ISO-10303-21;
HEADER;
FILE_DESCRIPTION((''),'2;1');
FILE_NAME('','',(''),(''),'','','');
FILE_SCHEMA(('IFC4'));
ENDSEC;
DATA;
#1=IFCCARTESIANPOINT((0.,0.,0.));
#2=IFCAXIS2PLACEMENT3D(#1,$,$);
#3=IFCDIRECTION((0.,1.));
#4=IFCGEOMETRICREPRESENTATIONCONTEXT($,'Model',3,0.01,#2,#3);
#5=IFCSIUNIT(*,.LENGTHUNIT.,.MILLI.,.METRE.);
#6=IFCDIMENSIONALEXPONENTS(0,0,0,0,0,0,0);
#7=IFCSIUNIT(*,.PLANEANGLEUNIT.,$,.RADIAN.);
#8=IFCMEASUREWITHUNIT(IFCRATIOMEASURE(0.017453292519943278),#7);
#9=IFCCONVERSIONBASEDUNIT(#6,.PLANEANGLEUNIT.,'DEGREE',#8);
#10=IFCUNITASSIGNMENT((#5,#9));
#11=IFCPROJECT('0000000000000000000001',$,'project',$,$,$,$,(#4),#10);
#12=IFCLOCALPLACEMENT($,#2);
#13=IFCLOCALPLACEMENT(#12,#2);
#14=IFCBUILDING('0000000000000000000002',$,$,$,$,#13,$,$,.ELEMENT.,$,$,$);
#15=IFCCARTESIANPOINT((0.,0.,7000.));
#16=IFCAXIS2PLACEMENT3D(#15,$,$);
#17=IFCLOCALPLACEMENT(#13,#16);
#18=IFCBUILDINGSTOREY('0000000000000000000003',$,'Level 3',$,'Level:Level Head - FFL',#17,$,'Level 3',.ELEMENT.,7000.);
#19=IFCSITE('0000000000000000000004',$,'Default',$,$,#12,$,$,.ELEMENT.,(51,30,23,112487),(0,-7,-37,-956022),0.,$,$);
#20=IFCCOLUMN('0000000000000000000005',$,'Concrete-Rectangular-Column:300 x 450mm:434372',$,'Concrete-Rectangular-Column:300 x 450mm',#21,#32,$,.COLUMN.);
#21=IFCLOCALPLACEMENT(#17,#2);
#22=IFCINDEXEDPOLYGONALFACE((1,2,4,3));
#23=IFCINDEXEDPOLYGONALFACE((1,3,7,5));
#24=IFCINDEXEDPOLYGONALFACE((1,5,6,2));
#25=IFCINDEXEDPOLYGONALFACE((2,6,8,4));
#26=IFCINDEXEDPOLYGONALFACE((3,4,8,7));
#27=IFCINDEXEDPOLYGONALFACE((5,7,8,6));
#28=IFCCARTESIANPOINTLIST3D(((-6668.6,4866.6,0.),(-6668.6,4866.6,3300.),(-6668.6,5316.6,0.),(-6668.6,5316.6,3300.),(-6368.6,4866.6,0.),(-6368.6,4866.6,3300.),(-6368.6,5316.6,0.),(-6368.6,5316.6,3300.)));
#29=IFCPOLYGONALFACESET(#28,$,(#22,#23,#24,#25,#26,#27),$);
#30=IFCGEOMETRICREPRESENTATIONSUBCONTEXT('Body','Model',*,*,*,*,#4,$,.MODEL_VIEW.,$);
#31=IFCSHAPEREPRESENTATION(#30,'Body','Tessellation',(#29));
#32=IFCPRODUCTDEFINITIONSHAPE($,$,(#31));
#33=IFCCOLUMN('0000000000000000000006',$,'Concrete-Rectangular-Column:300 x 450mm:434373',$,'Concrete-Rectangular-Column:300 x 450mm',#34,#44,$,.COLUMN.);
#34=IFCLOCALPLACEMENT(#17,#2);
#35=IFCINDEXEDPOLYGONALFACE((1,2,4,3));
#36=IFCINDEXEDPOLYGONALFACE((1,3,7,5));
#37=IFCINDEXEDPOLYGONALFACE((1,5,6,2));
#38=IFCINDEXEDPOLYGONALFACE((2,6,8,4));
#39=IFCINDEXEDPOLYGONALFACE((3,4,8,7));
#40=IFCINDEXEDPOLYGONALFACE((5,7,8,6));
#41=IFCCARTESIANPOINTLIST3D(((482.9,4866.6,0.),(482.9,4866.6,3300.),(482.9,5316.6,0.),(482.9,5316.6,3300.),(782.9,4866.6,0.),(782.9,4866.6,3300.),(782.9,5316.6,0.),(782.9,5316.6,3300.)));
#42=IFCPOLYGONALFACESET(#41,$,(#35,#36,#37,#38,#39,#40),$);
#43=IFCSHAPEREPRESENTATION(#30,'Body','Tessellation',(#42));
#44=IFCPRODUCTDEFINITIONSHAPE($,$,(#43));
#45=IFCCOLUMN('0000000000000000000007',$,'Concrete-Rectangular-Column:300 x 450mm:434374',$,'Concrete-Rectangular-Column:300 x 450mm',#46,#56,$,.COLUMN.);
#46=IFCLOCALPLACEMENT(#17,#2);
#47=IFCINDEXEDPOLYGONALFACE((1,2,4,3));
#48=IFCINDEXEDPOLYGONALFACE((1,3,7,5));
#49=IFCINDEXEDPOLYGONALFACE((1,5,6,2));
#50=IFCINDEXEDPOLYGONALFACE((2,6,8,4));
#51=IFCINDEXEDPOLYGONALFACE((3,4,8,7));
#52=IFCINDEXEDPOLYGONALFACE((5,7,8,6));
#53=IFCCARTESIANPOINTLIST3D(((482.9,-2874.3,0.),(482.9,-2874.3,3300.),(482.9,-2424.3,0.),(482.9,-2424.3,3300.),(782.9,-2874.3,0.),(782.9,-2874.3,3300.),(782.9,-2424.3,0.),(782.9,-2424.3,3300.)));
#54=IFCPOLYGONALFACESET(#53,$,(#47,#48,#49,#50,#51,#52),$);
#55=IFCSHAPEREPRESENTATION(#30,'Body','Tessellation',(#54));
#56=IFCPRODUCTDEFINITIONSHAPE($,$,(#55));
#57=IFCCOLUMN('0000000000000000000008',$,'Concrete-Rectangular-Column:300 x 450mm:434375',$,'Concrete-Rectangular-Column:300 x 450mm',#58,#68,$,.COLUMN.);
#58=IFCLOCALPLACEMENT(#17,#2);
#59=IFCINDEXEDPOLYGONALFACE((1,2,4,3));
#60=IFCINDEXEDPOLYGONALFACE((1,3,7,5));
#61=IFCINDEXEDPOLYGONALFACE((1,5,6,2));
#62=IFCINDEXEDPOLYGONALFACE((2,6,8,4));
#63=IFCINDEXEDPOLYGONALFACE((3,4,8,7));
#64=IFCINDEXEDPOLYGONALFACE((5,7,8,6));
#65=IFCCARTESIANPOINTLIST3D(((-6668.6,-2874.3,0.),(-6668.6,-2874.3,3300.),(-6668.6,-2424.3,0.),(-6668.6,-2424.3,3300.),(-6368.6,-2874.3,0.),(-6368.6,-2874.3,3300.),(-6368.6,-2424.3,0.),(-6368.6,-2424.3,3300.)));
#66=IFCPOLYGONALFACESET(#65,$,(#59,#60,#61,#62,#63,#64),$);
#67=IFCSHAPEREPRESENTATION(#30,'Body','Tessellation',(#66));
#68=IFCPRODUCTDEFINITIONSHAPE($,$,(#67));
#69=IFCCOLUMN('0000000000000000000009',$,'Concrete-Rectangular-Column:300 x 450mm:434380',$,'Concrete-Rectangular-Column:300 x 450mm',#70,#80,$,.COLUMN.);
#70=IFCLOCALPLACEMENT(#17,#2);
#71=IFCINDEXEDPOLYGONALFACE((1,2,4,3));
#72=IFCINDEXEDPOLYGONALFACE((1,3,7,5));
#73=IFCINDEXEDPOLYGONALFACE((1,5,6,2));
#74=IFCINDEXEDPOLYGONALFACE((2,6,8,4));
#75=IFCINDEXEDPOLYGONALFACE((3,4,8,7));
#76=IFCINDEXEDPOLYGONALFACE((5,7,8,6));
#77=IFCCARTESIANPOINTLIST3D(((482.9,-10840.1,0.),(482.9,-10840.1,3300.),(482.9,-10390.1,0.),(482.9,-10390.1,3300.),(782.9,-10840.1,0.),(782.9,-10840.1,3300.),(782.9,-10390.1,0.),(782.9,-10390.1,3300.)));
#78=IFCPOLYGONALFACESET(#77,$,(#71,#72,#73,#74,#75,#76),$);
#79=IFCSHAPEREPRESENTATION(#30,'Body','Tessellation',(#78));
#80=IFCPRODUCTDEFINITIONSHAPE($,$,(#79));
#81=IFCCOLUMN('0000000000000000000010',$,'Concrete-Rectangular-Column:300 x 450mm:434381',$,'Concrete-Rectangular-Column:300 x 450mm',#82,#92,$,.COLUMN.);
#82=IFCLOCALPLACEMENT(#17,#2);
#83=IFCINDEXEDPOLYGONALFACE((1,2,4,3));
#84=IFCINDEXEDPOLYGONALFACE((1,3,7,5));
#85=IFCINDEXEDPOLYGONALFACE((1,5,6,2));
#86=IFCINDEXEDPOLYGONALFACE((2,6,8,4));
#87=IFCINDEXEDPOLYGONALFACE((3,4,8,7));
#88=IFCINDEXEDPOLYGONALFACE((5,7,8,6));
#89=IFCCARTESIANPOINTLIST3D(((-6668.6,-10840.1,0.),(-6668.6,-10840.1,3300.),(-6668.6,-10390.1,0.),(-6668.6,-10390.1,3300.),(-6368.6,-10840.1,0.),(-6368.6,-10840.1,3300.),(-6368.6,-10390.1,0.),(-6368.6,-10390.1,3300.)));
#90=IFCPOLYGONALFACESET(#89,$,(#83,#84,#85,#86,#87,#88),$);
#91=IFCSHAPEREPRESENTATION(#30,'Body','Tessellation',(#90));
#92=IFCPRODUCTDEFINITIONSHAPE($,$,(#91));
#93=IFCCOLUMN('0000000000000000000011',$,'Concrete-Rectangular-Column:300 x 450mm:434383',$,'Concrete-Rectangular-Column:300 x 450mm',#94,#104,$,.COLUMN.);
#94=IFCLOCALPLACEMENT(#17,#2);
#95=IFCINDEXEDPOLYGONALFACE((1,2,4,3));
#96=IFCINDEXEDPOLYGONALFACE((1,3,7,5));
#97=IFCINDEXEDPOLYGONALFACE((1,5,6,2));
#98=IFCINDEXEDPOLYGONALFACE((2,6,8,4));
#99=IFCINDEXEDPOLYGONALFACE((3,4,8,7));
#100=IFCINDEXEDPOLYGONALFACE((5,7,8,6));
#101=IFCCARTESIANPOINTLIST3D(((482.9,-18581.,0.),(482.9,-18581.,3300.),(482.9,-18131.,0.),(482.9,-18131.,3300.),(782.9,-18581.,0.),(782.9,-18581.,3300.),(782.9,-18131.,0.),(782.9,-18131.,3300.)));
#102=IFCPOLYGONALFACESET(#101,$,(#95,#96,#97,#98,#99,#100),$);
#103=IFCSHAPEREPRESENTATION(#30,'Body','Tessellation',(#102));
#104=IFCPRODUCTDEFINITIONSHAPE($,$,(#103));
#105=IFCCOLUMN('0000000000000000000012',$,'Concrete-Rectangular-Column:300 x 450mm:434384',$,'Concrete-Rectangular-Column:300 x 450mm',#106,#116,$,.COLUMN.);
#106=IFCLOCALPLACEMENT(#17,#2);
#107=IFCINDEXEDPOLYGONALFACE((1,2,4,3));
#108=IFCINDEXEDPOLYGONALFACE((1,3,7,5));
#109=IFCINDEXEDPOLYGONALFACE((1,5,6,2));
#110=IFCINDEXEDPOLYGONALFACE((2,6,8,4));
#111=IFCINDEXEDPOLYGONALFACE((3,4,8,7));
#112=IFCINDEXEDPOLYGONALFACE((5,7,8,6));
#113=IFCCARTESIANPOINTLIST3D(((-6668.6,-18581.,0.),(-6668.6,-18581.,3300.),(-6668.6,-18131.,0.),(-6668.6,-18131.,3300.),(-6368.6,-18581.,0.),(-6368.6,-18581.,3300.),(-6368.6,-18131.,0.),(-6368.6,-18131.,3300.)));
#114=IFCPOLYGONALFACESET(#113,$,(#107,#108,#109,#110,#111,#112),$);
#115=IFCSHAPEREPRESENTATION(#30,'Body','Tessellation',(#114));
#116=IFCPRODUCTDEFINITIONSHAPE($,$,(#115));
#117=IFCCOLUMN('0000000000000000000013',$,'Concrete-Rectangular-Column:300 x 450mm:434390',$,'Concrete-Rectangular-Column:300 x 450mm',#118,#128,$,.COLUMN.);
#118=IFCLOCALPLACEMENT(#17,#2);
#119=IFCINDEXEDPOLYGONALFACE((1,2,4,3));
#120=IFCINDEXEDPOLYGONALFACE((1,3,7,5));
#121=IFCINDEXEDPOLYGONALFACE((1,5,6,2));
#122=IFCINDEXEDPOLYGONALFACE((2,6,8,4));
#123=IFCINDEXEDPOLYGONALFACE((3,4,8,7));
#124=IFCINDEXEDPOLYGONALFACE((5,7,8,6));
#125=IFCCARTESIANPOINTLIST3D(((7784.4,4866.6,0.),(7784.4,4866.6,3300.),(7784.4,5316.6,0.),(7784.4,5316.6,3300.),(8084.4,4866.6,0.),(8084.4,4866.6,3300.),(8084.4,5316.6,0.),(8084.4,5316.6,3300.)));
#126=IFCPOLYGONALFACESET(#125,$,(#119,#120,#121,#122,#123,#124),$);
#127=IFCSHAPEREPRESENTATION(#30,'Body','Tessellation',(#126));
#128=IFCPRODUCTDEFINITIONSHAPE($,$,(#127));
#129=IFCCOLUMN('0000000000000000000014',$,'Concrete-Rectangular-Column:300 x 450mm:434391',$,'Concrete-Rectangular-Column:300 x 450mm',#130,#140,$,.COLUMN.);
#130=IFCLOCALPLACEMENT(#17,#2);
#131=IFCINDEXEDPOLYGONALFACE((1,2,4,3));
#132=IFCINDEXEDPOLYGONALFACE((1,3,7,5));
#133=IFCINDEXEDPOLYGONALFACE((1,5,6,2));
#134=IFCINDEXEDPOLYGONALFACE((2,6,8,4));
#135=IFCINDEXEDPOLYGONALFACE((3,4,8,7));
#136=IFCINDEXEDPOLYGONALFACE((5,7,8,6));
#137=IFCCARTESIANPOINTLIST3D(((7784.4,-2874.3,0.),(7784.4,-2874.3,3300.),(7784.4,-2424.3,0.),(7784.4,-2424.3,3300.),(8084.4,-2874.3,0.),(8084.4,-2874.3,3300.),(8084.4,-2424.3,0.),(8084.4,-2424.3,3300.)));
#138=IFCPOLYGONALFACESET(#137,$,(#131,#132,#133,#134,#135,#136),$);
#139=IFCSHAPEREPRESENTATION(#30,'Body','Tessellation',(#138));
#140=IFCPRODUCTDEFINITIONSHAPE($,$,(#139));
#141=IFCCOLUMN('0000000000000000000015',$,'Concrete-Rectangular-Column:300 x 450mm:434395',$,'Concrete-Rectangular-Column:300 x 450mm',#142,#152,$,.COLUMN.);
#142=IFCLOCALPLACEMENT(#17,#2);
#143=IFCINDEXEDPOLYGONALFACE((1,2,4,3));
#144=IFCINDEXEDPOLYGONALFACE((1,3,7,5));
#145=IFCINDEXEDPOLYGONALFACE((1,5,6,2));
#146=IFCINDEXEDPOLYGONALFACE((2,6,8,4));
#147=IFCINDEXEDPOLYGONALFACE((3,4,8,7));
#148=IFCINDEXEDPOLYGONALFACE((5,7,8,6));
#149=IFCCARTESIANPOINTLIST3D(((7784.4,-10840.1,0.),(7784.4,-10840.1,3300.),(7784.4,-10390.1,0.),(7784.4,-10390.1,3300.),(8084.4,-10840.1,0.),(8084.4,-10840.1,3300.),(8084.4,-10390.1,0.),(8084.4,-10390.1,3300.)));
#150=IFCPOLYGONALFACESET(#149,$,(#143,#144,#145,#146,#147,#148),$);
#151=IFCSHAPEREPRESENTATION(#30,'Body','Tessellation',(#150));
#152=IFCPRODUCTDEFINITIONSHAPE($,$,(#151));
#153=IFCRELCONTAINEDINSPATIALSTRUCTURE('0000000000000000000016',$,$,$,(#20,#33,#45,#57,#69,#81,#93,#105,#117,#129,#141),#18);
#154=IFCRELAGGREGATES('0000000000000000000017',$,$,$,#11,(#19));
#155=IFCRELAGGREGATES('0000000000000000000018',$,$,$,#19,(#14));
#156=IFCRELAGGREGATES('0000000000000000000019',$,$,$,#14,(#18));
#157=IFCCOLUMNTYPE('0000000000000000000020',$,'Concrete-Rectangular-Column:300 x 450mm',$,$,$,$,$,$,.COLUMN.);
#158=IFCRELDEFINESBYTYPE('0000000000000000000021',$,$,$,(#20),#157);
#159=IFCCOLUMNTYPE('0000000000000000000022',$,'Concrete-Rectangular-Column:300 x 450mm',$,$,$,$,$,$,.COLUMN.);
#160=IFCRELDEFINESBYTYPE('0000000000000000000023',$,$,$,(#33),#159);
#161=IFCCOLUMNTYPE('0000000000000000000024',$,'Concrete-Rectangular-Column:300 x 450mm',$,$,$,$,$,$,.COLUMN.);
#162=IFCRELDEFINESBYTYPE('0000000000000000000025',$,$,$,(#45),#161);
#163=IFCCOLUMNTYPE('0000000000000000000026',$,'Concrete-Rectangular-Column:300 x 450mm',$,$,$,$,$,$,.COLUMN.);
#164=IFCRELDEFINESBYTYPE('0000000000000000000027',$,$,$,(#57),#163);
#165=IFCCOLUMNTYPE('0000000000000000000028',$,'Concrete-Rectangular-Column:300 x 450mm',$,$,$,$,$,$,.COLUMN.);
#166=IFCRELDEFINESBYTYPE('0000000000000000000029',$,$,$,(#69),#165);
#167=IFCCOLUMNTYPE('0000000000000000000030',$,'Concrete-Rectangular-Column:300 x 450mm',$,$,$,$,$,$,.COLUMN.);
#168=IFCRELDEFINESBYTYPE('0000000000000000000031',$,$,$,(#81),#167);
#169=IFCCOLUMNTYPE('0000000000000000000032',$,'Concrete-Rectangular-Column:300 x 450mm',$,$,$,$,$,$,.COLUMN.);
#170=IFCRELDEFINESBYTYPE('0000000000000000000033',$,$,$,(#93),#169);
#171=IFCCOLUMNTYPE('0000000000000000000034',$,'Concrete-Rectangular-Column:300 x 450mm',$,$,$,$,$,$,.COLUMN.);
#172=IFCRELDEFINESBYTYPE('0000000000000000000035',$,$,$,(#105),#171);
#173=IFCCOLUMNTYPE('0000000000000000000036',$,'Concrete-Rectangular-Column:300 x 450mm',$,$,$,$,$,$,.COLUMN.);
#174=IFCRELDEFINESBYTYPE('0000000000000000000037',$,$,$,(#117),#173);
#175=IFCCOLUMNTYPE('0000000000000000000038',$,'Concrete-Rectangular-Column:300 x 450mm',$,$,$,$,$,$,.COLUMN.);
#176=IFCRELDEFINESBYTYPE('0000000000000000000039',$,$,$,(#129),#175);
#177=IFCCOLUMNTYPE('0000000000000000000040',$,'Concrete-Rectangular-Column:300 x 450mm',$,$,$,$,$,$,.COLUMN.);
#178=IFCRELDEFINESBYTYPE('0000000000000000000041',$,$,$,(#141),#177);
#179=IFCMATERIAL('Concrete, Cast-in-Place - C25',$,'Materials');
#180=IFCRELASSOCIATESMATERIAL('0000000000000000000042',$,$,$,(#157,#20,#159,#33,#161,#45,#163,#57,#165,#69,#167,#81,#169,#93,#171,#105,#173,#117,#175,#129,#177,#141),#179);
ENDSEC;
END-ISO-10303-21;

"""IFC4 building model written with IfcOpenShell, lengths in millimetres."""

from ifc_helpers import new_model, entity, si_unit, converted_unit, direction, frame, origin, place, context, subcontext, project, spatial, indexed_curve, outline, extrude, source, transform, mapped, material, type_object, type_shapes, element, save


model = new_model("IFC4")

# Units and contexts
model_context = context("Model", 3, precision=0.01, world=origin(), true_north=direction((0.0, 1.0)))
body_context = subcontext(model_context, "Body", "Model", "MODEL_VIEW")
ifc_project = project(units=[si_unit("LENGTHUNIT", "METRE", prefix="MILLI"), converted_unit("PLANEANGLEUNIT", "DEGREE", entity("IfcRatioMeasure", 0.017453292519943278), si_unit("PLANEANGLEUNIT", "RADIAN"), dimensions=[0, 0, 0, 0, 0, 0, 0])], contexts=[model_context])

# Site, building, storey
site_placement = place(None, origin())
site = spatial("IfcSite", under=ifc_project, at=site_placement, Name="Default", CompositionType="ELEMENT", RefLatitude=(51, 30, 23, 112487), RefLongitude=(0, -7, -37, -956022), RefElevation=0.0)
building_placement = place(site_placement, origin())
building = spatial("IfcBuilding", under=site, at=building_placement, CompositionType="ELEMENT")
storey_placement = place(building_placement, frame((0.0, 0.0, 7000.0)))
storey = spatial("IfcBuildingStorey", under=building, at=storey_placement, Name="Level 3", ObjectType="Level:Level Head - FFL", LongName="Level 3", CompositionType="ELEMENT", Elevation=7000.0)

# Columns
ifc_material = material(Name="Concrete, Cast-in-Place - C25", Category="Materials")
column_type_1 = type_object("IfcColumnType", Name="Concrete-Rectangular-Column:300 x 450mm", PredefinedType="COLUMN", material=ifc_material)
shared_shape_1 = source(origin(), body_context, "Body", "SweptSolid", [
    extrude(outline(indexed_curve([(-225.0, -150.0), (225.0, -150.0), (225.0, 150.0), (-225.0, 150.0), (-225.0, -150.0)], self_intersect=False)), frame((-6518.6, 5091.6, 7000.0), z_axis=(0.0, 0.0, 1.0), x_axis=(0.0, -1.0, 0.0)), (0.0, 0.0, 1.0), 3300.0),
])
type_shapes(column_type_1, [shared_shape_1])
column_1_placement = place(storey_placement, frame((0.0, 0.0, -7000.0)))
element("IfcColumn", 1, at=column_1_placement, inside=storey, type_object=column_type_1, material=ifc_material, Name="Concrete-Rectangular-Column:300 x 450mm:434372", ObjectType="Concrete-Rectangular-Column:300 x 450mm", PredefinedType="COLUMN", context=body_context, shape_type="MappedRepresentation", body=[
    mapped(shared_shape_1, transform((0.0, 0.0, 0.0), scale=1.0)),
])
column_type_2 = type_object("IfcColumnType", Name="Concrete-Rectangular-Column:300 x 450mm", PredefinedType="COLUMN", material=ifc_material)
shared_shape_2 = source(origin(), body_context, "Body", "SweptSolid", [
    extrude(outline(indexed_curve([(-225.0, -150.0), (225.0, -150.0), (225.0, 150.0), (-225.0, 150.0), (-225.0, -150.0)], self_intersect=False)), frame((632.9, 5091.6, 7000.0), z_axis=(0.0, 0.0, 1.0), x_axis=(0.0, -1.0, 0.0)), (0.0, 0.0, 1.0), 3300.0),
])
type_shapes(column_type_2, [shared_shape_2])
column_2_placement = place(storey_placement, frame((0.0, 0.0, -7000.0)))
element("IfcColumn", 2, at=column_2_placement, inside=storey, type_object=column_type_2, material=ifc_material, Name="Concrete-Rectangular-Column:300 x 450mm:434373", ObjectType="Concrete-Rectangular-Column:300 x 450mm", PredefinedType="COLUMN", context=body_context, shape_type="MappedRepresentation", body=[
    mapped(shared_shape_2, transform((0.0, 0.0, 0.0), scale=1.0)),
])
column_type_3 = type_object("IfcColumnType", Name="Concrete-Rectangular-Column:300 x 450mm", PredefinedType="COLUMN", material=ifc_material)
shared_shape_3 = source(origin(), body_context, "Body", "SweptSolid", [
    extrude(outline(indexed_curve([(-225.0, -150.0), (225.0, -150.0), (225.0, 150.0), (-225.0, 150.0), (-225.0, -150.0)], self_intersect=False)), frame((632.9, -2649.3, 7000.0), z_axis=(0.0, 0.0, 1.0), x_axis=(0.0, -1.0, 0.0)), (0.0, 0.0, 1.0), 3300.0),
])
type_shapes(column_type_3, [shared_shape_3])
column_3_placement = place(storey_placement, frame((0.0, 0.0, -7000.0)))
element("IfcColumn", 3, at=column_3_placement, inside=storey, type_object=column_type_3, material=ifc_material, Name="Concrete-Rectangular-Column:300 x 450mm:434374", ObjectType="Concrete-Rectangular-Column:300 x 450mm", PredefinedType="COLUMN", context=body_context, shape_type="MappedRepresentation", body=[
    mapped(shared_shape_3, transform((0.0, 0.0, 0.0), scale=1.0)),
])
column_type_4 = type_object("IfcColumnType", Name="Concrete-Rectangular-Column:300 x 450mm", PredefinedType="COLUMN", material=ifc_material)
shared_shape_4 = source(origin(), body_context, "Body", "SweptSolid", [
    extrude(outline(indexed_curve([(-225.0, -150.0), (225.0, -150.0), (225.0, 150.0), (-225.0, 150.0), (-225.0, -150.0)], self_intersect=False)), frame((-6518.6, -2649.3, 7000.0), z_axis=(0.0, 0.0, 1.0), x_axis=(0.0, -1.0, 0.0)), (0.0, 0.0, 1.0), 3300.0),
])
type_shapes(column_type_4, [shared_shape_4])
column_4_placement = place(storey_placement, frame((0.0, 0.0, -7000.0)))
element("IfcColumn", 4, at=column_4_placement, inside=storey, type_object=column_type_4, material=ifc_material, Name="Concrete-Rectangular-Column:300 x 450mm:434375", ObjectType="Concrete-Rectangular-Column:300 x 450mm", PredefinedType="COLUMN", context=body_context, shape_type="MappedRepresentation", body=[
    mapped(shared_shape_4, transform((0.0, 0.0, 0.0), scale=1.0)),
])
column_type_5 = type_object("IfcColumnType", Name="Concrete-Rectangular-Column:300 x 450mm", PredefinedType="COLUMN", material=ifc_material)
shared_shape_5 = source(origin(), body_context, "Body", "SweptSolid", [
    extrude(outline(indexed_curve([(-225.0, -150.0), (225.0, -150.0), (225.0, 150.0), (-225.0, 150.0), (-225.0, -150.0)], self_intersect=False)), frame((632.9, -10615.1, 7000.0), z_axis=(0.0, 0.0, 1.0), x_axis=(0.0, -1.0, 0.0)), (0.0, 0.0, 1.0), 3300.0),
])
type_shapes(column_type_5, [shared_shape_5])
column_5_placement = place(storey_placement, frame((0.0, 0.0, -7000.0)))
element("IfcColumn", 5, at=column_5_placement, inside=storey, type_object=column_type_5, material=ifc_material, Name="Concrete-Rectangular-Column:300 x 450mm:434380", ObjectType="Concrete-Rectangular-Column:300 x 450mm", PredefinedType="COLUMN", context=body_context, shape_type="MappedRepresentation", body=[
    mapped(shared_shape_5, transform((0.0, 0.0, 0.0), scale=1.0)),
])
column_type_6 = type_object("IfcColumnType", Name="Concrete-Rectangular-Column:300 x 450mm", PredefinedType="COLUMN", material=ifc_material)
shared_shape_6 = source(origin(), body_context, "Body", "SweptSolid", [
    extrude(outline(indexed_curve([(-225.0, -150.0), (225.0, -150.0), (225.0, 150.0), (-225.0, 150.0), (-225.0, -150.0)], self_intersect=False)), frame((-6518.6, -10615.1, 7000.0), z_axis=(0.0, 0.0, 1.0), x_axis=(0.0, -1.0, 0.0)), (0.0, 0.0, 1.0), 3300.0),
])
type_shapes(column_type_6, [shared_shape_6])
column_6_placement = place(storey_placement, frame((0.0, 0.0, -7000.0)))
element("IfcColumn", 6, at=column_6_placement, inside=storey, type_object=column_type_6, material=ifc_material, Name="Concrete-Rectangular-Column:300 x 450mm:434381", ObjectType="Concrete-Rectangular-Column:300 x 450mm", PredefinedType="COLUMN", context=body_context, shape_type="MappedRepresentation", body=[
    mapped(shared_shape_6, transform((0.0, 0.0, 0.0), scale=1.0)),
])
column_type_7 = type_object("IfcColumnType", Name="Concrete-Rectangular-Column:300 x 450mm", PredefinedType="COLUMN", material=ifc_material)
shared_shape_7 = source(origin(), body_context, "Body", "SweptSolid", [
    extrude(outline(indexed_curve([(-225.0, -150.0), (225.0, -150.0), (225.0, 150.0), (-225.0, 150.0), (-225.0, -150.0)], self_intersect=False)), frame((632.9, -18356.0, 7000.0), z_axis=(0.0, 0.0, 1.0), x_axis=(0.0, -1.0, 0.0)), (0.0, 0.0, 1.0), 3300.0),
])
type_shapes(column_type_7, [shared_shape_7])
column_7_placement = place(storey_placement, frame((0.0, 0.0, -7000.0)))
element("IfcColumn", 7, at=column_7_placement, inside=storey, type_object=column_type_7, material=ifc_material, Name="Concrete-Rectangular-Column:300 x 450mm:434383", ObjectType="Concrete-Rectangular-Column:300 x 450mm", PredefinedType="COLUMN", context=body_context, shape_type="MappedRepresentation", body=[
    mapped(shared_shape_7, transform((0.0, 0.0, 0.0), scale=1.0)),
])
column_type_8 = type_object("IfcColumnType", Name="Concrete-Rectangular-Column:300 x 450mm", PredefinedType="COLUMN", material=ifc_material)
shared_shape_8 = source(origin(), body_context, "Body", "SweptSolid", [
    extrude(outline(indexed_curve([(-225.0, -150.0), (225.0, -150.0), (225.0, 150.0), (-225.0, 150.0), (-225.0, -150.0)], self_intersect=False)), frame((-6518.6, -18356.0, 7000.0), z_axis=(0.0, 0.0, 1.0), x_axis=(0.0, -1.0, 0.0)), (0.0, 0.0, 1.0), 3300.0),
])
type_shapes(column_type_8, [shared_shape_8])
column_8_placement = place(storey_placement, frame((0.0, 0.0, -7000.0)))
element("IfcColumn", 8, at=column_8_placement, inside=storey, type_object=column_type_8, material=ifc_material, Name="Concrete-Rectangular-Column:300 x 450mm:434384", ObjectType="Concrete-Rectangular-Column:300 x 450mm", PredefinedType="COLUMN", context=body_context, shape_type="MappedRepresentation", body=[
    mapped(shared_shape_8, transform((0.0, 0.0, 0.0), scale=1.0)),
])
column_type_9 = type_object("IfcColumnType", Name="Concrete-Rectangular-Column:300 x 450mm", PredefinedType="COLUMN", material=ifc_material)
shared_shape_9 = source(origin(), body_context, "Body", "SweptSolid", [
    extrude(outline(indexed_curve([(-225.0, -150.0), (225.0, -150.0), (225.0, 150.0), (-225.0, 150.0), (-225.0, -150.0)], self_intersect=False)), frame((7934.4, 5091.6, 7000.0), z_axis=(0.0, 0.0, 1.0), x_axis=(0.0, -1.0, 0.0)), (0.0, 0.0, 1.0), 3300.0),
])
type_shapes(column_type_9, [shared_shape_9])
column_9_placement = place(storey_placement, frame((0.0, 0.0, -7000.0)))
element("IfcColumn", 9, at=column_9_placement, inside=storey, type_object=column_type_9, material=ifc_material, Name="Concrete-Rectangular-Column:300 x 450mm:434390", ObjectType="Concrete-Rectangular-Column:300 x 450mm", PredefinedType="COLUMN", context=body_context, shape_type="MappedRepresentation", body=[
    mapped(shared_shape_9, transform((0.0, 0.0, 0.0), scale=1.0)),
])
column_type_10 = type_object("IfcColumnType", Name="Concrete-Rectangular-Column:300 x 450mm", PredefinedType="COLUMN", material=ifc_material)
shared_shape_10 = source(origin(), body_context, "Body", "SweptSolid", [
    extrude(outline(indexed_curve([(-225.0, -150.0), (225.0, -150.0), (225.0, 150.0), (-225.0, 150.0), (-225.0, -150.0)], self_intersect=False)), frame((7934.4, -2649.3, 7000.0), z_axis=(0.0, 0.0, 1.0), x_axis=(0.0, -1.0, 0.0)), (0.0, 0.0, 1.0), 3300.0),
])
type_shapes(column_type_10, [shared_shape_10])
column_10_placement = place(storey_placement, frame((0.0, 0.0, -7000.0)))
element("IfcColumn", 10, at=column_10_placement, inside=storey, type_object=column_type_10, material=ifc_material, Name="Concrete-Rectangular-Column:300 x 450mm:434391", ObjectType="Concrete-Rectangular-Column:300 x 450mm", PredefinedType="COLUMN", context=body_context, shape_type="MappedRepresentation", body=[
    mapped(shared_shape_10, transform((0.0, 0.0, 0.0), scale=1.0)),
])
column_type_11 = type_object("IfcColumnType", Name="Concrete-Rectangular-Column:300 x 450mm", PredefinedType="COLUMN", material=ifc_material)
shared_shape_11 = source(origin(), body_context, "Body", "SweptSolid", [
    extrude(outline(indexed_curve([(-225.0, -150.0), (225.0, -150.0), (225.0, 150.0), (-225.0, 150.0), (-225.0, -150.0)], self_intersect=False)), frame((7934.4, -10615.1, 7000.0), z_axis=(0.0, 0.0, 1.0), x_axis=(0.0, -1.0, 0.0)), (0.0, 0.0, 1.0), 3300.0),
])
type_shapes(column_type_11, [shared_shape_11])
column_11_placement = place(storey_placement, frame((0.0, 0.0, -7000.0)))
element("IfcColumn", 11, at=column_11_placement, inside=storey, type_object=column_type_11, material=ifc_material, Name="Concrete-Rectangular-Column:300 x 450mm:434395", ObjectType="Concrete-Rectangular-Column:300 x 450mm", PredefinedType="COLUMN", context=body_context, shape_type="MappedRepresentation", body=[
    mapped(shared_shape_11, transform((0.0, 0.0, 0.0), scale=1.0)),
])

save(model, "model.ifc")
